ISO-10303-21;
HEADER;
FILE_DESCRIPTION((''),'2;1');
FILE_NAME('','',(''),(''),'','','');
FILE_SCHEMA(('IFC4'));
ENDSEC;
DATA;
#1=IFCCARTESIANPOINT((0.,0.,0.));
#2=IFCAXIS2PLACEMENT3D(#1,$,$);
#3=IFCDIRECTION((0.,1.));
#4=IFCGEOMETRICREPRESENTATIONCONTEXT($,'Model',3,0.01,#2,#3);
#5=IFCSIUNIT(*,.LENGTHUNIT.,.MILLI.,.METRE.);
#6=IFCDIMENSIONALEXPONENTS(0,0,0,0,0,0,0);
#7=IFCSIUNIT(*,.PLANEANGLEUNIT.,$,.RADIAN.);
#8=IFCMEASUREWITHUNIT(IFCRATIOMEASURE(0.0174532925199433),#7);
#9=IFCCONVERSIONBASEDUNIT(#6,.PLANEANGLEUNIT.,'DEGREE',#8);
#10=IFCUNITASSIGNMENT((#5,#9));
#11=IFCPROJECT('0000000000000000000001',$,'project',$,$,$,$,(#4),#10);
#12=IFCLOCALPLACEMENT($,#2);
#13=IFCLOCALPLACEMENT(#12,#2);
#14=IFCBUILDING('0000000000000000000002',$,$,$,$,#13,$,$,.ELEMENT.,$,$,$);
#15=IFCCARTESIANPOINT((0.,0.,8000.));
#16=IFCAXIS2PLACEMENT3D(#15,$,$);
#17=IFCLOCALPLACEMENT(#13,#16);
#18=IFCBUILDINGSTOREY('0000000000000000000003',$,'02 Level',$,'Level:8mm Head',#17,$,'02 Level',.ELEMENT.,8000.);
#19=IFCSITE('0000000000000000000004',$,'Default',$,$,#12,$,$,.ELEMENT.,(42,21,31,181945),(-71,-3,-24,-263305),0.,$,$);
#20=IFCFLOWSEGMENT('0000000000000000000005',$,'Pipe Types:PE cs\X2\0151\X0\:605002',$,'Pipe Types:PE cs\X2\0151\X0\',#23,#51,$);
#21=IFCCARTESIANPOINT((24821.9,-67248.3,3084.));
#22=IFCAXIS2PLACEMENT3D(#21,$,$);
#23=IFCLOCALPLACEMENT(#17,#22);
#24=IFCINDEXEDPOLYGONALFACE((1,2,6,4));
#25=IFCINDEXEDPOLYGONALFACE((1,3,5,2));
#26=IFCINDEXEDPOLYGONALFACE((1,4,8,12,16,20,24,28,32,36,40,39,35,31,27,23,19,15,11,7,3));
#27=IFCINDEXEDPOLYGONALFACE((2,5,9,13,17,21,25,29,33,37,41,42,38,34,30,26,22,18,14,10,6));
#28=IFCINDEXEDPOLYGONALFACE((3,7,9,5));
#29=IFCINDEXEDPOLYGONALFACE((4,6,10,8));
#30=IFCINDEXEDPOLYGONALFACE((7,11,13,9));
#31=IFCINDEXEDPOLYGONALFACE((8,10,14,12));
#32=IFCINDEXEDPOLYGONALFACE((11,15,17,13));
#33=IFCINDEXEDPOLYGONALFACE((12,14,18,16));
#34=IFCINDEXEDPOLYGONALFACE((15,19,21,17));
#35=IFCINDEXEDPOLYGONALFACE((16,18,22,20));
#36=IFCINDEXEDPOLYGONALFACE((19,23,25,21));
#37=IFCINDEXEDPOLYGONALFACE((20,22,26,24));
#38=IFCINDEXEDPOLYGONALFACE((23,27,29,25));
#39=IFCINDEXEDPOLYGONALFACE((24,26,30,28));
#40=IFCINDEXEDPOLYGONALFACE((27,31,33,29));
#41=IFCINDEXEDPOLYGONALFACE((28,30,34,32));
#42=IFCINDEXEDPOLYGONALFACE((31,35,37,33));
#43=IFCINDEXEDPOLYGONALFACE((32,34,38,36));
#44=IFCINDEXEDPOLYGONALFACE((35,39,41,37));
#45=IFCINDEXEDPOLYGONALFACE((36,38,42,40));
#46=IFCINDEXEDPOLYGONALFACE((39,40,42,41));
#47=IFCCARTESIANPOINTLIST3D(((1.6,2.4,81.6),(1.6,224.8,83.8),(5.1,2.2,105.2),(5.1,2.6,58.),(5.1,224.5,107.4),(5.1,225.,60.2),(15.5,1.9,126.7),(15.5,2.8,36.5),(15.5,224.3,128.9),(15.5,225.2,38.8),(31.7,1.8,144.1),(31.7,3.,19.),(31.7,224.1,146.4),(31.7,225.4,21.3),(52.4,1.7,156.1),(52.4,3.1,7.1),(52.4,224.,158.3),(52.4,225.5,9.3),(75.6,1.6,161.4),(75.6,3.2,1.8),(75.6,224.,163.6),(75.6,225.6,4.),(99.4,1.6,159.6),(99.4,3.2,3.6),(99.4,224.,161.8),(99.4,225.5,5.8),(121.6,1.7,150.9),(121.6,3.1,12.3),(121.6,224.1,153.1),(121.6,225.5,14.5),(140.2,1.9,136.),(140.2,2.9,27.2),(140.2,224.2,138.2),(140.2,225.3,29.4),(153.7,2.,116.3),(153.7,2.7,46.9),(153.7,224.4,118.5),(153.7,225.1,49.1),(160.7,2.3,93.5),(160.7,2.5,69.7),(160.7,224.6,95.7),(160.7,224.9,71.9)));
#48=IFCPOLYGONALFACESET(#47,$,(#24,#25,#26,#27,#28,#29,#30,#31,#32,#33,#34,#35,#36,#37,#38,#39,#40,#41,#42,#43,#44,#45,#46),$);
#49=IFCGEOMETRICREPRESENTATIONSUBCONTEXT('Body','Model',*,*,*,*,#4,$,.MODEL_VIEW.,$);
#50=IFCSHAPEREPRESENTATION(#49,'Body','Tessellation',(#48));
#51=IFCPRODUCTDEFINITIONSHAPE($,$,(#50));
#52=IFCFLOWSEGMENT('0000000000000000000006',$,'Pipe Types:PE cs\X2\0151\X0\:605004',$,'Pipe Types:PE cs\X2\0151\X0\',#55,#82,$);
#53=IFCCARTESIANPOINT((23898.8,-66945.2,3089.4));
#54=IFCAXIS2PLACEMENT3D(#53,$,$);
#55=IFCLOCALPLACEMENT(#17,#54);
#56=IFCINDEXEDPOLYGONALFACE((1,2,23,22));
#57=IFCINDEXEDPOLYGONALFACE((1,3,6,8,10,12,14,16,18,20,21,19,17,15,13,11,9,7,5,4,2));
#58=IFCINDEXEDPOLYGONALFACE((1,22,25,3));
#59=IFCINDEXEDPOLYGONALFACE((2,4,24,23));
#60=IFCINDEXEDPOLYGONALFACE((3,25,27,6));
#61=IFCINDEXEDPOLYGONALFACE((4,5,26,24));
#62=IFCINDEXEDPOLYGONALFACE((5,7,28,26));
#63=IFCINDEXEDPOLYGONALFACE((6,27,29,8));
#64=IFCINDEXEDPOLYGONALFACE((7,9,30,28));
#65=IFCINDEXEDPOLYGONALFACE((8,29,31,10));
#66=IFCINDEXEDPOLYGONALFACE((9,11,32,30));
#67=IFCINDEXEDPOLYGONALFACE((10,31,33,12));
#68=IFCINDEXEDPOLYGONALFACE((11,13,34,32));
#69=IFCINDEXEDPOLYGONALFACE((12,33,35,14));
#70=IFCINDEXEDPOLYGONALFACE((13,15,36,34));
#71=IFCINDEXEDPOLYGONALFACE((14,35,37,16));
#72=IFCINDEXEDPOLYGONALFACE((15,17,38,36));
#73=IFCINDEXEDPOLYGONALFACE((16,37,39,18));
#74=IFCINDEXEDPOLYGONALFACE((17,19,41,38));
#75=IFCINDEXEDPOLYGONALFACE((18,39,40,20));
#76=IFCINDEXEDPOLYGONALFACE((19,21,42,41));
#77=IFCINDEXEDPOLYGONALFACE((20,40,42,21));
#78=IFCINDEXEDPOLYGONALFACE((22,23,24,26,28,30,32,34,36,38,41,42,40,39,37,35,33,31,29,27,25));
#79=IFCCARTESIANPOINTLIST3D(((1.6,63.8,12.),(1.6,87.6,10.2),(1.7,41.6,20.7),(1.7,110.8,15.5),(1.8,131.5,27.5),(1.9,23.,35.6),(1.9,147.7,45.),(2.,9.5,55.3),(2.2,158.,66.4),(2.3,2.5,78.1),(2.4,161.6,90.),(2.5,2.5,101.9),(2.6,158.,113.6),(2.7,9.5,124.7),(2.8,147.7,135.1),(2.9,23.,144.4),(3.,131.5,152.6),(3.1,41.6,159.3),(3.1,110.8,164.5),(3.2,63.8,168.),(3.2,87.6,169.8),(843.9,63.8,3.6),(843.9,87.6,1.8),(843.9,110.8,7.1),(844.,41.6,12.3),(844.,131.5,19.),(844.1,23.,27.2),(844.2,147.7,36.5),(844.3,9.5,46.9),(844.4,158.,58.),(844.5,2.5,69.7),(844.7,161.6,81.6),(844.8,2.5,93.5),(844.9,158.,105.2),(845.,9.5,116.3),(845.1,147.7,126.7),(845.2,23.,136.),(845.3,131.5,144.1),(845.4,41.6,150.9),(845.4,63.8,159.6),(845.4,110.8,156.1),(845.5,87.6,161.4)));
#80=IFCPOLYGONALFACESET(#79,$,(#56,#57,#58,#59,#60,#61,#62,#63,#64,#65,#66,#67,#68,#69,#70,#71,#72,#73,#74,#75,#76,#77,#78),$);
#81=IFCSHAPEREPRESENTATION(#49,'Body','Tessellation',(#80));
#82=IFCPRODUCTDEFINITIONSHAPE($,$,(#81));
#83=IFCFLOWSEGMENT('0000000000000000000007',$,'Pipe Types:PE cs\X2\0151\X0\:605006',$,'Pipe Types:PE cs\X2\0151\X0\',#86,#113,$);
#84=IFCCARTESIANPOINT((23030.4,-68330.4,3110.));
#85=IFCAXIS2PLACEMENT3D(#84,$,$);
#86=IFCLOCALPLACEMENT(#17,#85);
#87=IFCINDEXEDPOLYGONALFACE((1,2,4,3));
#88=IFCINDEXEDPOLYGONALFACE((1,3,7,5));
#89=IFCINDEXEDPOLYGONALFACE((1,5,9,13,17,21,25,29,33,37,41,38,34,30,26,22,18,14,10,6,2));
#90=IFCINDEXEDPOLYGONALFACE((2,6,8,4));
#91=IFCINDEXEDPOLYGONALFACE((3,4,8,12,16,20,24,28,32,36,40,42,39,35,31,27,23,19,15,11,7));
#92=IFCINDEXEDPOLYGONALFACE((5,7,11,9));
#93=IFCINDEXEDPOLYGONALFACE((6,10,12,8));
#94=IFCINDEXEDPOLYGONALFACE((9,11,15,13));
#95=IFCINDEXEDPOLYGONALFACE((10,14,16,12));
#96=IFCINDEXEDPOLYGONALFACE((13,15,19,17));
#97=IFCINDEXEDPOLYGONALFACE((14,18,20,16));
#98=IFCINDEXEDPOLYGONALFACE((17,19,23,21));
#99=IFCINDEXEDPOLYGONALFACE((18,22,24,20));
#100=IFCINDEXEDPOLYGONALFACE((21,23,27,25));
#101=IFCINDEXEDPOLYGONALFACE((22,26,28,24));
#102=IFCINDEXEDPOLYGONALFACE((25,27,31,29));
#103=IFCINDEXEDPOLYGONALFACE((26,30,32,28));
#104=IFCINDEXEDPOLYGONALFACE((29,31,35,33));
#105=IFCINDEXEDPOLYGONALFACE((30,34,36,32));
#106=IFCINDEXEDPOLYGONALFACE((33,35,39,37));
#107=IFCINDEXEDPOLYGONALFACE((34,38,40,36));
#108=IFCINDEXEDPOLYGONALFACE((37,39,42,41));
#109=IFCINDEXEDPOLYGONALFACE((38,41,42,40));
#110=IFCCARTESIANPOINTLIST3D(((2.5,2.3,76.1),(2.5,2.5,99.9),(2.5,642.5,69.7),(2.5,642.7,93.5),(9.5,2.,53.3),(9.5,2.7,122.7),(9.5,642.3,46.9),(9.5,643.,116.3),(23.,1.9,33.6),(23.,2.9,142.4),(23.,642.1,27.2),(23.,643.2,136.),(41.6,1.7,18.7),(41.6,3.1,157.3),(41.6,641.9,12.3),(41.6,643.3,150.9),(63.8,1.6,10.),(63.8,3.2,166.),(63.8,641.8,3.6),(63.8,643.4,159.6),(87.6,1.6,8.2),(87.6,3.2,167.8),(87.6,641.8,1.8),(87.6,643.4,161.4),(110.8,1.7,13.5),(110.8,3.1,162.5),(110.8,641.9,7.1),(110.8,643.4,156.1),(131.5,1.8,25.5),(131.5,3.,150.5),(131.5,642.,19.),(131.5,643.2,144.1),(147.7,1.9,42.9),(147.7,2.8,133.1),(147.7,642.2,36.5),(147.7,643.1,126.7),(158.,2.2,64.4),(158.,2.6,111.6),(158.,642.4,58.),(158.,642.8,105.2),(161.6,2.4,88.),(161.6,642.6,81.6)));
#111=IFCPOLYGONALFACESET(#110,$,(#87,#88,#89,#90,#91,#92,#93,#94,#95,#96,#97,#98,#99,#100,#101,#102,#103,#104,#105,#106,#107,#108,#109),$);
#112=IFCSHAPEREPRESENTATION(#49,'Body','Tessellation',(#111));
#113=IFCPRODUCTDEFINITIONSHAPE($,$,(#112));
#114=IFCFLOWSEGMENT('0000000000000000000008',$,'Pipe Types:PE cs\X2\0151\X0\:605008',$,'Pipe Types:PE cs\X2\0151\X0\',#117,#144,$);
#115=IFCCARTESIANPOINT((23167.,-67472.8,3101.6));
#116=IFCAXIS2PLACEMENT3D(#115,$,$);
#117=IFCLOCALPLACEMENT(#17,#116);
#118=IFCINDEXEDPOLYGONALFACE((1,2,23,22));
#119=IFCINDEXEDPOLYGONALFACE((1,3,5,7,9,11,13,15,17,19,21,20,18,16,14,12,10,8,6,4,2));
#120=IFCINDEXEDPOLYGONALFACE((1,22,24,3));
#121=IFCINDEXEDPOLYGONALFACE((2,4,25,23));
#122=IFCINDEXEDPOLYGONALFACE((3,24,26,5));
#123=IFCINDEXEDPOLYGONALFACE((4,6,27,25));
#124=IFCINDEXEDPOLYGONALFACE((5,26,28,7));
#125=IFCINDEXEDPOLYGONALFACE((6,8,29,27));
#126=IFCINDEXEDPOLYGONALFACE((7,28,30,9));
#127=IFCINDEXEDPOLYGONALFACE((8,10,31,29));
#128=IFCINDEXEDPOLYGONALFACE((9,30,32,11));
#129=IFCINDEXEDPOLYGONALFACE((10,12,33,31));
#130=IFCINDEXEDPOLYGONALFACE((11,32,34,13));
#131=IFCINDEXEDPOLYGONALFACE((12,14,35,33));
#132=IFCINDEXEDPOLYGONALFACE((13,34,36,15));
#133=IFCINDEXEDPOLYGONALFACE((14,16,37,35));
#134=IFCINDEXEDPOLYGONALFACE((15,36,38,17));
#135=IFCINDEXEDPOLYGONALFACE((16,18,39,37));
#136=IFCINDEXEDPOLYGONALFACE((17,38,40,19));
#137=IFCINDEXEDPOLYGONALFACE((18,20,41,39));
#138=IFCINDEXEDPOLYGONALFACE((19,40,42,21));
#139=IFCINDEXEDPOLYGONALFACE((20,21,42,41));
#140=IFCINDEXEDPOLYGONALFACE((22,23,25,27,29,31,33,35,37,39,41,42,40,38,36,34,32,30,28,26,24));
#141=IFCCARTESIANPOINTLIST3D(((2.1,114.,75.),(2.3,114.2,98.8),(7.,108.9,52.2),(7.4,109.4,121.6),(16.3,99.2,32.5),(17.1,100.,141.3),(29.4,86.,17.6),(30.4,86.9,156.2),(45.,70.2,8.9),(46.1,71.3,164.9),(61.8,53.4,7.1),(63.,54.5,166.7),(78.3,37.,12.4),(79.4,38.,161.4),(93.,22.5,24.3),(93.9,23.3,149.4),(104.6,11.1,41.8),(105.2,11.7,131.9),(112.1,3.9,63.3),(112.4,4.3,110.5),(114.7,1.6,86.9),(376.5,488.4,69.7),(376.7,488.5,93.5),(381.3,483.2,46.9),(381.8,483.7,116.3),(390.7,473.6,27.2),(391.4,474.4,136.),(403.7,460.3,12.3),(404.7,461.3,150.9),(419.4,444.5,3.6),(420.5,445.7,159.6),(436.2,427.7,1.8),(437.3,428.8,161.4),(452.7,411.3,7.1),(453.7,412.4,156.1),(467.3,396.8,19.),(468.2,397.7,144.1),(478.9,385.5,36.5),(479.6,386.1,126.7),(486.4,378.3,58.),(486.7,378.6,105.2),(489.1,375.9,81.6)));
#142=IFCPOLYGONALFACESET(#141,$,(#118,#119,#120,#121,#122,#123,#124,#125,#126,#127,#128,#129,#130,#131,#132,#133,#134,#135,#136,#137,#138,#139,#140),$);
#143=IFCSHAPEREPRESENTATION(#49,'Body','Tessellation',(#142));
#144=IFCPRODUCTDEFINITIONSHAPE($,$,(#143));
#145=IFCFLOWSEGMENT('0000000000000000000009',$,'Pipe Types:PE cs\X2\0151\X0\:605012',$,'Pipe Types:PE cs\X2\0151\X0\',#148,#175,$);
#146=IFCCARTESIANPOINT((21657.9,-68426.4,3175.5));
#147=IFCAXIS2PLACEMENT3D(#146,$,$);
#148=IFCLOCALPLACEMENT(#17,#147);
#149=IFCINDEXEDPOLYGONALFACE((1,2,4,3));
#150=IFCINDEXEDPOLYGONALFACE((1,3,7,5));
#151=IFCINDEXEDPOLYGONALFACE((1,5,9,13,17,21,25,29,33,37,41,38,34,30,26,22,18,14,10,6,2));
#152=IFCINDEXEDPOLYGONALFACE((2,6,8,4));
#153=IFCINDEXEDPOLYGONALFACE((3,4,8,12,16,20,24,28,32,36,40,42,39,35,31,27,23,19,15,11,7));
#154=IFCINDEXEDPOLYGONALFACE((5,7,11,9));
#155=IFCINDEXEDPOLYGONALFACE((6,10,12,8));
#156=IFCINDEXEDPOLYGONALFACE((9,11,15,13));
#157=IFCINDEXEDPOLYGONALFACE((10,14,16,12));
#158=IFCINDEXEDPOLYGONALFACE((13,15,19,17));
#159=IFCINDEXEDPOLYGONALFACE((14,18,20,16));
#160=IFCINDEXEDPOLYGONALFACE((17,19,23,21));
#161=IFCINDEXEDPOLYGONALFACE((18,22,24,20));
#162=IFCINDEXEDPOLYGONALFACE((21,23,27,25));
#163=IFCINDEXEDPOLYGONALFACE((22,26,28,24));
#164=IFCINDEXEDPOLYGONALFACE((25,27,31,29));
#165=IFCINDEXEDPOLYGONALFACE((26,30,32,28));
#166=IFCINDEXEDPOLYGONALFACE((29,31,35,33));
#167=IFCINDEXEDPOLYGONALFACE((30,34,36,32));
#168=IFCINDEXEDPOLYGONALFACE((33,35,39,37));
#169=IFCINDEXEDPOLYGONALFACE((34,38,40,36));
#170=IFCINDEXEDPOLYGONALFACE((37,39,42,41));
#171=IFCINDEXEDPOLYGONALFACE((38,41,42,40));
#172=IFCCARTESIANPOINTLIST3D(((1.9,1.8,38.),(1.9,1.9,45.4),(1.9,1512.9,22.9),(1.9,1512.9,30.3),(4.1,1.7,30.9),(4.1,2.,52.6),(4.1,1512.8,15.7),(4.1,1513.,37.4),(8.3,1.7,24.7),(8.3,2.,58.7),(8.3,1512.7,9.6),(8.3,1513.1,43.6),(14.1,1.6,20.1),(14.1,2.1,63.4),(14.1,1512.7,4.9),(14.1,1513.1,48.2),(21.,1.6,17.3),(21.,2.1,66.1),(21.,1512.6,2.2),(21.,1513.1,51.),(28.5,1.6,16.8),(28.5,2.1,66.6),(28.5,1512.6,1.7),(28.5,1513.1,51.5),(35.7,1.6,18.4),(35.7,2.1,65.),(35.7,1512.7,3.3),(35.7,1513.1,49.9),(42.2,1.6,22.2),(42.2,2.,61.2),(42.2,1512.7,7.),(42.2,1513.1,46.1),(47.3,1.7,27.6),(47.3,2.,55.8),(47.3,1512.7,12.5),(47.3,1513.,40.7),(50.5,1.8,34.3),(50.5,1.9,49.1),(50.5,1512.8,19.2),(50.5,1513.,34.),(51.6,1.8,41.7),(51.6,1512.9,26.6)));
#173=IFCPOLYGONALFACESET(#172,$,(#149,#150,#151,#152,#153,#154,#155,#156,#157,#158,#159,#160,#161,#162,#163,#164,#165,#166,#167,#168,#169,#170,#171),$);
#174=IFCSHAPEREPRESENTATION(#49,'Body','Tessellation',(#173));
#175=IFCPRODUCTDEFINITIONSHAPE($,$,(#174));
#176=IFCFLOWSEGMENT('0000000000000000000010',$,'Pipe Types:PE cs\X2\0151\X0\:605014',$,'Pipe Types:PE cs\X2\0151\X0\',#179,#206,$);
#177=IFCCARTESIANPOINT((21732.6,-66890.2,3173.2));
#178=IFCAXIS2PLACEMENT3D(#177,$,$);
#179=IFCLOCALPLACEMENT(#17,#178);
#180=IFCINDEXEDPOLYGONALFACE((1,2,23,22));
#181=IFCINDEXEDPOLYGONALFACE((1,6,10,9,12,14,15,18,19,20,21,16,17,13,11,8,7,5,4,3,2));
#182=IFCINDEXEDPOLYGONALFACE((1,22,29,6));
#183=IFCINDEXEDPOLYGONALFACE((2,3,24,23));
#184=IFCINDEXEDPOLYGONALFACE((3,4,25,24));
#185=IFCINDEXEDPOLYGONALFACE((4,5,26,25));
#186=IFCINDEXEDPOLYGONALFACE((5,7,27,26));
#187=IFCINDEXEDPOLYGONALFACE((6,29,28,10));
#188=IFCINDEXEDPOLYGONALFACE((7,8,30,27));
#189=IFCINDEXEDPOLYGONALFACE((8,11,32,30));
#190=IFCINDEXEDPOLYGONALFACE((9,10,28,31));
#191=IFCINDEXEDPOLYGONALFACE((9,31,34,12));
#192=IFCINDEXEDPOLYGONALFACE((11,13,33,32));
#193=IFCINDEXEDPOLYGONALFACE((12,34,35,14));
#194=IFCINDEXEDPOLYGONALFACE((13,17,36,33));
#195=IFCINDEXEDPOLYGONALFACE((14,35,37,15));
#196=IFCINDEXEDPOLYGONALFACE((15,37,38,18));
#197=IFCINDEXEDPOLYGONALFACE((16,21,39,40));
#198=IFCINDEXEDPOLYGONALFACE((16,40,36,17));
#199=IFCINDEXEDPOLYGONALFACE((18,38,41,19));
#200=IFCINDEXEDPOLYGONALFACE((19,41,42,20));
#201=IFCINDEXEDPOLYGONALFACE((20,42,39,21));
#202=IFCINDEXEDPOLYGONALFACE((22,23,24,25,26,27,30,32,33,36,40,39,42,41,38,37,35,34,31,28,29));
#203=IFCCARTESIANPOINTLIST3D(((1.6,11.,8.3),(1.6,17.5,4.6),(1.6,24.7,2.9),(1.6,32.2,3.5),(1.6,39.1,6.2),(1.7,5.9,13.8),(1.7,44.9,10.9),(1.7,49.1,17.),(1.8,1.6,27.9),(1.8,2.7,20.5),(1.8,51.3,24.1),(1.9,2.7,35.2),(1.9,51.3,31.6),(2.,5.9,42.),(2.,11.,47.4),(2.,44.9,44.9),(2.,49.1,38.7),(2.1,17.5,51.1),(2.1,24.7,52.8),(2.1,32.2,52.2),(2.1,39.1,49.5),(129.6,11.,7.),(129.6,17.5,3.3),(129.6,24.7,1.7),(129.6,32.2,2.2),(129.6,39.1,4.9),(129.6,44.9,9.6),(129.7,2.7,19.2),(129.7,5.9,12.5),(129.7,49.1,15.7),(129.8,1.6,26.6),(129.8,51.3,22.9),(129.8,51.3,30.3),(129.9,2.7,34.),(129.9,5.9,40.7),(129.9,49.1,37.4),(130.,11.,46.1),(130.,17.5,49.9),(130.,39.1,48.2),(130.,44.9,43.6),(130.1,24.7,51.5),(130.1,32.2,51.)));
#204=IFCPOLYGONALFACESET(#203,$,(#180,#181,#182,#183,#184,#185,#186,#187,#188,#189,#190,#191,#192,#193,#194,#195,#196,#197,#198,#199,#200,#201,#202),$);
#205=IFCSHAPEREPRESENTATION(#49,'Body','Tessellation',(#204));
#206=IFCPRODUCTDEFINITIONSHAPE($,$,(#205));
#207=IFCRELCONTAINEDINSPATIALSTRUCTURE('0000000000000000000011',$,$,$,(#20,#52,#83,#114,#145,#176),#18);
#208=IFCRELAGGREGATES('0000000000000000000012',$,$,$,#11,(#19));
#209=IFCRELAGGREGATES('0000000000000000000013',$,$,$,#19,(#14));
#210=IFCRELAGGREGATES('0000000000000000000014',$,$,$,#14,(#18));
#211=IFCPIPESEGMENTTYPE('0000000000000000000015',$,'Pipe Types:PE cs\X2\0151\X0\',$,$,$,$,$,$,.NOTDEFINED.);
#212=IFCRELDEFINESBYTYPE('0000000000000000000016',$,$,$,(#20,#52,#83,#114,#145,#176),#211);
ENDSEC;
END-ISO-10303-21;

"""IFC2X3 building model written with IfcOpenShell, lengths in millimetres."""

from ifc_helpers import new_model, entity, si_unit, converted_unit, direction, frame, frame_2d, origin, origin_2d_with_axis, place, context, subcontext, project, spatial, circle, extrude, type_object, element, save


model = new_model("IFC2X3")

# Units and contexts
model_context = context("Model", 3, precision=0.01, world=origin(), true_north=direction((0.0, 1.0)))
body_context = subcontext(model_context, "Body", "Model", "MODEL_VIEW")
ifc_project = project(units=[si_unit("LENGTHUNIT", "METRE", prefix="MILLI"), converted_unit("PLANEANGLEUNIT", "DEGREE", entity("IfcRatioMeasure", 0.0174532925199433), si_unit("PLANEANGLEUNIT", "RADIAN"), dimensions=[0, 0, 0, 0, 0, 0, 0])], contexts=[model_context])

# Site, building, storey
site_placement = place(None, origin())
site = spatial("IfcSite", under=ifc_project, at=site_placement, Name="Default", CompositionType="ELEMENT", RefLatitude=(42, 21, 31, 181945), RefLongitude=(-71, -3, -24, -263305), RefElevation=0.0)
building_placement = place(site_placement, origin())
building = spatial("IfcBuilding", under=site, at=building_placement, CompositionType="ELEMENT")
storey_placement = place(building_placement, frame((0.0, 0.0, 8000.0)))
storey = spatial("IfcBuildingStorey", under=building, at=storey_placement, Name="02 Level", ObjectType="Level:8mm Head", LongName="02 Level", CompositionType="ELEMENT", Elevation=8000.0)

# Flow segments
pipe_segment_type = type_object("IfcPipeSegmentType", Name="Pipe Types:PE cső", PredefinedType="NOTDEFINED")
flow_segment_1_placement = place(storey_placement, frame((24821.9, -67248.3, 3084.0)))
element("IfcFlowSegment", 1, at=flow_segment_1_placement, inside=storey, type_object=pipe_segment_type, Name="Pipe Types:PE cső:605002", ObjectType="Pipe Types:PE cső", context=body_context, shape_type="SweptSolid", body=[
    extrude(circle(Radius=80.0, at=origin_2d_with_axis()), frame((81.6, 2.4, 81.6), z_axis=(0.0, 0.99995, 0.01), x_axis=(-1.0, 0.0, 0.0)), (0.0, 0.0, 1.0), 222.4),
])
flow_segment_2_placement = place(storey_placement, frame((23898.8, -66945.2, 3089.4)))
element("IfcFlowSegment", 2, at=flow_segment_2_placement, inside=storey, type_object=pipe_segment_type, Name="Pipe Types:PE cső:605004", ObjectType="Pipe Types:PE cső", context=body_context, shape_type="SweptSolid", body=[
    extrude(circle(Radius=80.0, at=origin_2d_with_axis()), frame((844.7, 81.6, 81.6), z_axis=(-0.99995, 0.0, 0.01), x_axis=(0.0, 1.0, 0.0)), (0.0, 0.0, 1.0), 842.3),
])
flow_segment_3_placement = place(storey_placement, frame((23030.4, -68330.4, 3110.0)))
element("IfcFlowSegment", 3, at=flow_segment_3_placement, inside=storey, type_object=pipe_segment_type, Name="Pipe Types:PE cső:605006", ObjectType="Pipe Types:PE cső", context=body_context, shape_type="SweptSolid", body=[
    extrude(circle(Radius=80.0, at=frame_2d((0.0, 0.0), x_axis=(1.0, 0.0))), frame((81.6, 2.4, 88.0), z_axis=(0.0, 0.99995, -0.01), x_axis=(1.0, 0.0, 0.0)), (0.0, 0.0, 1.0), 640.2),
])
flow_segment_4_placement = place(storey_placement, frame((23167.0, -67472.8, 3101.6)))
element("IfcFlowSegment", 4, at=flow_segment_4_placement, inside=storey, type_object=pipe_segment_type, Name="Pipe Types:PE cső:605008", ObjectType="Pipe Types:PE cső", context=body_context, shape_type="SweptSolid", body=[
    extrude(circle(Radius=80.0, at=origin_2d_with_axis()), frame((432.5, 432.5, 81.6), z_axis=(-0.707071, -0.707071, 0.01), x_axis=(0.707107, -0.707107, 0.0)), (0.0, 0.0, 1.0), 529.4),
])
flow_segment_5_placement = place(storey_placement, frame((21657.9, -68426.4, 3175.5)))
element("IfcFlowSegment", 5, at=flow_segment_5_placement, inside=storey, type_object=pipe_segment_type, Name="Pipe Types:PE cső:605012", ObjectType="Pipe Types:PE cső", context=body_context, shape_type="SweptSolid", body=[
    extrude(circle(Radius=25.0, at=origin_2d_with_axis()), frame((26.6, 1512.9, 26.6), z_axis=(0.0, -0.99995, 0.01), x_axis=(1.0, 0.0, 0.0)), (0.0, 0.0, 1.0), 1511.1),
])
flow_segment_6_placement = place(storey_placement, frame((21732.6, -66890.2, 3173.2)))
element("IfcFlowSegment", 6, at=flow_segment_6_placement, inside=storey, type_object=pipe_segment_type, Name="Pipe Types:PE cső:605014", ObjectType="Pipe Types:PE cső", context=body_context, shape_type="SweptSolid", body=[
    extrude(circle(Radius=25.0, at=origin_2d_with_axis()), frame((129.8, 26.6, 26.6), z_axis=(-0.99995, 0.0, 0.01), x_axis=(0.0, -1.0, 0.0)), (0.0, 0.0, 1.0), 128.0),
])

save(model, "model.ifc")
